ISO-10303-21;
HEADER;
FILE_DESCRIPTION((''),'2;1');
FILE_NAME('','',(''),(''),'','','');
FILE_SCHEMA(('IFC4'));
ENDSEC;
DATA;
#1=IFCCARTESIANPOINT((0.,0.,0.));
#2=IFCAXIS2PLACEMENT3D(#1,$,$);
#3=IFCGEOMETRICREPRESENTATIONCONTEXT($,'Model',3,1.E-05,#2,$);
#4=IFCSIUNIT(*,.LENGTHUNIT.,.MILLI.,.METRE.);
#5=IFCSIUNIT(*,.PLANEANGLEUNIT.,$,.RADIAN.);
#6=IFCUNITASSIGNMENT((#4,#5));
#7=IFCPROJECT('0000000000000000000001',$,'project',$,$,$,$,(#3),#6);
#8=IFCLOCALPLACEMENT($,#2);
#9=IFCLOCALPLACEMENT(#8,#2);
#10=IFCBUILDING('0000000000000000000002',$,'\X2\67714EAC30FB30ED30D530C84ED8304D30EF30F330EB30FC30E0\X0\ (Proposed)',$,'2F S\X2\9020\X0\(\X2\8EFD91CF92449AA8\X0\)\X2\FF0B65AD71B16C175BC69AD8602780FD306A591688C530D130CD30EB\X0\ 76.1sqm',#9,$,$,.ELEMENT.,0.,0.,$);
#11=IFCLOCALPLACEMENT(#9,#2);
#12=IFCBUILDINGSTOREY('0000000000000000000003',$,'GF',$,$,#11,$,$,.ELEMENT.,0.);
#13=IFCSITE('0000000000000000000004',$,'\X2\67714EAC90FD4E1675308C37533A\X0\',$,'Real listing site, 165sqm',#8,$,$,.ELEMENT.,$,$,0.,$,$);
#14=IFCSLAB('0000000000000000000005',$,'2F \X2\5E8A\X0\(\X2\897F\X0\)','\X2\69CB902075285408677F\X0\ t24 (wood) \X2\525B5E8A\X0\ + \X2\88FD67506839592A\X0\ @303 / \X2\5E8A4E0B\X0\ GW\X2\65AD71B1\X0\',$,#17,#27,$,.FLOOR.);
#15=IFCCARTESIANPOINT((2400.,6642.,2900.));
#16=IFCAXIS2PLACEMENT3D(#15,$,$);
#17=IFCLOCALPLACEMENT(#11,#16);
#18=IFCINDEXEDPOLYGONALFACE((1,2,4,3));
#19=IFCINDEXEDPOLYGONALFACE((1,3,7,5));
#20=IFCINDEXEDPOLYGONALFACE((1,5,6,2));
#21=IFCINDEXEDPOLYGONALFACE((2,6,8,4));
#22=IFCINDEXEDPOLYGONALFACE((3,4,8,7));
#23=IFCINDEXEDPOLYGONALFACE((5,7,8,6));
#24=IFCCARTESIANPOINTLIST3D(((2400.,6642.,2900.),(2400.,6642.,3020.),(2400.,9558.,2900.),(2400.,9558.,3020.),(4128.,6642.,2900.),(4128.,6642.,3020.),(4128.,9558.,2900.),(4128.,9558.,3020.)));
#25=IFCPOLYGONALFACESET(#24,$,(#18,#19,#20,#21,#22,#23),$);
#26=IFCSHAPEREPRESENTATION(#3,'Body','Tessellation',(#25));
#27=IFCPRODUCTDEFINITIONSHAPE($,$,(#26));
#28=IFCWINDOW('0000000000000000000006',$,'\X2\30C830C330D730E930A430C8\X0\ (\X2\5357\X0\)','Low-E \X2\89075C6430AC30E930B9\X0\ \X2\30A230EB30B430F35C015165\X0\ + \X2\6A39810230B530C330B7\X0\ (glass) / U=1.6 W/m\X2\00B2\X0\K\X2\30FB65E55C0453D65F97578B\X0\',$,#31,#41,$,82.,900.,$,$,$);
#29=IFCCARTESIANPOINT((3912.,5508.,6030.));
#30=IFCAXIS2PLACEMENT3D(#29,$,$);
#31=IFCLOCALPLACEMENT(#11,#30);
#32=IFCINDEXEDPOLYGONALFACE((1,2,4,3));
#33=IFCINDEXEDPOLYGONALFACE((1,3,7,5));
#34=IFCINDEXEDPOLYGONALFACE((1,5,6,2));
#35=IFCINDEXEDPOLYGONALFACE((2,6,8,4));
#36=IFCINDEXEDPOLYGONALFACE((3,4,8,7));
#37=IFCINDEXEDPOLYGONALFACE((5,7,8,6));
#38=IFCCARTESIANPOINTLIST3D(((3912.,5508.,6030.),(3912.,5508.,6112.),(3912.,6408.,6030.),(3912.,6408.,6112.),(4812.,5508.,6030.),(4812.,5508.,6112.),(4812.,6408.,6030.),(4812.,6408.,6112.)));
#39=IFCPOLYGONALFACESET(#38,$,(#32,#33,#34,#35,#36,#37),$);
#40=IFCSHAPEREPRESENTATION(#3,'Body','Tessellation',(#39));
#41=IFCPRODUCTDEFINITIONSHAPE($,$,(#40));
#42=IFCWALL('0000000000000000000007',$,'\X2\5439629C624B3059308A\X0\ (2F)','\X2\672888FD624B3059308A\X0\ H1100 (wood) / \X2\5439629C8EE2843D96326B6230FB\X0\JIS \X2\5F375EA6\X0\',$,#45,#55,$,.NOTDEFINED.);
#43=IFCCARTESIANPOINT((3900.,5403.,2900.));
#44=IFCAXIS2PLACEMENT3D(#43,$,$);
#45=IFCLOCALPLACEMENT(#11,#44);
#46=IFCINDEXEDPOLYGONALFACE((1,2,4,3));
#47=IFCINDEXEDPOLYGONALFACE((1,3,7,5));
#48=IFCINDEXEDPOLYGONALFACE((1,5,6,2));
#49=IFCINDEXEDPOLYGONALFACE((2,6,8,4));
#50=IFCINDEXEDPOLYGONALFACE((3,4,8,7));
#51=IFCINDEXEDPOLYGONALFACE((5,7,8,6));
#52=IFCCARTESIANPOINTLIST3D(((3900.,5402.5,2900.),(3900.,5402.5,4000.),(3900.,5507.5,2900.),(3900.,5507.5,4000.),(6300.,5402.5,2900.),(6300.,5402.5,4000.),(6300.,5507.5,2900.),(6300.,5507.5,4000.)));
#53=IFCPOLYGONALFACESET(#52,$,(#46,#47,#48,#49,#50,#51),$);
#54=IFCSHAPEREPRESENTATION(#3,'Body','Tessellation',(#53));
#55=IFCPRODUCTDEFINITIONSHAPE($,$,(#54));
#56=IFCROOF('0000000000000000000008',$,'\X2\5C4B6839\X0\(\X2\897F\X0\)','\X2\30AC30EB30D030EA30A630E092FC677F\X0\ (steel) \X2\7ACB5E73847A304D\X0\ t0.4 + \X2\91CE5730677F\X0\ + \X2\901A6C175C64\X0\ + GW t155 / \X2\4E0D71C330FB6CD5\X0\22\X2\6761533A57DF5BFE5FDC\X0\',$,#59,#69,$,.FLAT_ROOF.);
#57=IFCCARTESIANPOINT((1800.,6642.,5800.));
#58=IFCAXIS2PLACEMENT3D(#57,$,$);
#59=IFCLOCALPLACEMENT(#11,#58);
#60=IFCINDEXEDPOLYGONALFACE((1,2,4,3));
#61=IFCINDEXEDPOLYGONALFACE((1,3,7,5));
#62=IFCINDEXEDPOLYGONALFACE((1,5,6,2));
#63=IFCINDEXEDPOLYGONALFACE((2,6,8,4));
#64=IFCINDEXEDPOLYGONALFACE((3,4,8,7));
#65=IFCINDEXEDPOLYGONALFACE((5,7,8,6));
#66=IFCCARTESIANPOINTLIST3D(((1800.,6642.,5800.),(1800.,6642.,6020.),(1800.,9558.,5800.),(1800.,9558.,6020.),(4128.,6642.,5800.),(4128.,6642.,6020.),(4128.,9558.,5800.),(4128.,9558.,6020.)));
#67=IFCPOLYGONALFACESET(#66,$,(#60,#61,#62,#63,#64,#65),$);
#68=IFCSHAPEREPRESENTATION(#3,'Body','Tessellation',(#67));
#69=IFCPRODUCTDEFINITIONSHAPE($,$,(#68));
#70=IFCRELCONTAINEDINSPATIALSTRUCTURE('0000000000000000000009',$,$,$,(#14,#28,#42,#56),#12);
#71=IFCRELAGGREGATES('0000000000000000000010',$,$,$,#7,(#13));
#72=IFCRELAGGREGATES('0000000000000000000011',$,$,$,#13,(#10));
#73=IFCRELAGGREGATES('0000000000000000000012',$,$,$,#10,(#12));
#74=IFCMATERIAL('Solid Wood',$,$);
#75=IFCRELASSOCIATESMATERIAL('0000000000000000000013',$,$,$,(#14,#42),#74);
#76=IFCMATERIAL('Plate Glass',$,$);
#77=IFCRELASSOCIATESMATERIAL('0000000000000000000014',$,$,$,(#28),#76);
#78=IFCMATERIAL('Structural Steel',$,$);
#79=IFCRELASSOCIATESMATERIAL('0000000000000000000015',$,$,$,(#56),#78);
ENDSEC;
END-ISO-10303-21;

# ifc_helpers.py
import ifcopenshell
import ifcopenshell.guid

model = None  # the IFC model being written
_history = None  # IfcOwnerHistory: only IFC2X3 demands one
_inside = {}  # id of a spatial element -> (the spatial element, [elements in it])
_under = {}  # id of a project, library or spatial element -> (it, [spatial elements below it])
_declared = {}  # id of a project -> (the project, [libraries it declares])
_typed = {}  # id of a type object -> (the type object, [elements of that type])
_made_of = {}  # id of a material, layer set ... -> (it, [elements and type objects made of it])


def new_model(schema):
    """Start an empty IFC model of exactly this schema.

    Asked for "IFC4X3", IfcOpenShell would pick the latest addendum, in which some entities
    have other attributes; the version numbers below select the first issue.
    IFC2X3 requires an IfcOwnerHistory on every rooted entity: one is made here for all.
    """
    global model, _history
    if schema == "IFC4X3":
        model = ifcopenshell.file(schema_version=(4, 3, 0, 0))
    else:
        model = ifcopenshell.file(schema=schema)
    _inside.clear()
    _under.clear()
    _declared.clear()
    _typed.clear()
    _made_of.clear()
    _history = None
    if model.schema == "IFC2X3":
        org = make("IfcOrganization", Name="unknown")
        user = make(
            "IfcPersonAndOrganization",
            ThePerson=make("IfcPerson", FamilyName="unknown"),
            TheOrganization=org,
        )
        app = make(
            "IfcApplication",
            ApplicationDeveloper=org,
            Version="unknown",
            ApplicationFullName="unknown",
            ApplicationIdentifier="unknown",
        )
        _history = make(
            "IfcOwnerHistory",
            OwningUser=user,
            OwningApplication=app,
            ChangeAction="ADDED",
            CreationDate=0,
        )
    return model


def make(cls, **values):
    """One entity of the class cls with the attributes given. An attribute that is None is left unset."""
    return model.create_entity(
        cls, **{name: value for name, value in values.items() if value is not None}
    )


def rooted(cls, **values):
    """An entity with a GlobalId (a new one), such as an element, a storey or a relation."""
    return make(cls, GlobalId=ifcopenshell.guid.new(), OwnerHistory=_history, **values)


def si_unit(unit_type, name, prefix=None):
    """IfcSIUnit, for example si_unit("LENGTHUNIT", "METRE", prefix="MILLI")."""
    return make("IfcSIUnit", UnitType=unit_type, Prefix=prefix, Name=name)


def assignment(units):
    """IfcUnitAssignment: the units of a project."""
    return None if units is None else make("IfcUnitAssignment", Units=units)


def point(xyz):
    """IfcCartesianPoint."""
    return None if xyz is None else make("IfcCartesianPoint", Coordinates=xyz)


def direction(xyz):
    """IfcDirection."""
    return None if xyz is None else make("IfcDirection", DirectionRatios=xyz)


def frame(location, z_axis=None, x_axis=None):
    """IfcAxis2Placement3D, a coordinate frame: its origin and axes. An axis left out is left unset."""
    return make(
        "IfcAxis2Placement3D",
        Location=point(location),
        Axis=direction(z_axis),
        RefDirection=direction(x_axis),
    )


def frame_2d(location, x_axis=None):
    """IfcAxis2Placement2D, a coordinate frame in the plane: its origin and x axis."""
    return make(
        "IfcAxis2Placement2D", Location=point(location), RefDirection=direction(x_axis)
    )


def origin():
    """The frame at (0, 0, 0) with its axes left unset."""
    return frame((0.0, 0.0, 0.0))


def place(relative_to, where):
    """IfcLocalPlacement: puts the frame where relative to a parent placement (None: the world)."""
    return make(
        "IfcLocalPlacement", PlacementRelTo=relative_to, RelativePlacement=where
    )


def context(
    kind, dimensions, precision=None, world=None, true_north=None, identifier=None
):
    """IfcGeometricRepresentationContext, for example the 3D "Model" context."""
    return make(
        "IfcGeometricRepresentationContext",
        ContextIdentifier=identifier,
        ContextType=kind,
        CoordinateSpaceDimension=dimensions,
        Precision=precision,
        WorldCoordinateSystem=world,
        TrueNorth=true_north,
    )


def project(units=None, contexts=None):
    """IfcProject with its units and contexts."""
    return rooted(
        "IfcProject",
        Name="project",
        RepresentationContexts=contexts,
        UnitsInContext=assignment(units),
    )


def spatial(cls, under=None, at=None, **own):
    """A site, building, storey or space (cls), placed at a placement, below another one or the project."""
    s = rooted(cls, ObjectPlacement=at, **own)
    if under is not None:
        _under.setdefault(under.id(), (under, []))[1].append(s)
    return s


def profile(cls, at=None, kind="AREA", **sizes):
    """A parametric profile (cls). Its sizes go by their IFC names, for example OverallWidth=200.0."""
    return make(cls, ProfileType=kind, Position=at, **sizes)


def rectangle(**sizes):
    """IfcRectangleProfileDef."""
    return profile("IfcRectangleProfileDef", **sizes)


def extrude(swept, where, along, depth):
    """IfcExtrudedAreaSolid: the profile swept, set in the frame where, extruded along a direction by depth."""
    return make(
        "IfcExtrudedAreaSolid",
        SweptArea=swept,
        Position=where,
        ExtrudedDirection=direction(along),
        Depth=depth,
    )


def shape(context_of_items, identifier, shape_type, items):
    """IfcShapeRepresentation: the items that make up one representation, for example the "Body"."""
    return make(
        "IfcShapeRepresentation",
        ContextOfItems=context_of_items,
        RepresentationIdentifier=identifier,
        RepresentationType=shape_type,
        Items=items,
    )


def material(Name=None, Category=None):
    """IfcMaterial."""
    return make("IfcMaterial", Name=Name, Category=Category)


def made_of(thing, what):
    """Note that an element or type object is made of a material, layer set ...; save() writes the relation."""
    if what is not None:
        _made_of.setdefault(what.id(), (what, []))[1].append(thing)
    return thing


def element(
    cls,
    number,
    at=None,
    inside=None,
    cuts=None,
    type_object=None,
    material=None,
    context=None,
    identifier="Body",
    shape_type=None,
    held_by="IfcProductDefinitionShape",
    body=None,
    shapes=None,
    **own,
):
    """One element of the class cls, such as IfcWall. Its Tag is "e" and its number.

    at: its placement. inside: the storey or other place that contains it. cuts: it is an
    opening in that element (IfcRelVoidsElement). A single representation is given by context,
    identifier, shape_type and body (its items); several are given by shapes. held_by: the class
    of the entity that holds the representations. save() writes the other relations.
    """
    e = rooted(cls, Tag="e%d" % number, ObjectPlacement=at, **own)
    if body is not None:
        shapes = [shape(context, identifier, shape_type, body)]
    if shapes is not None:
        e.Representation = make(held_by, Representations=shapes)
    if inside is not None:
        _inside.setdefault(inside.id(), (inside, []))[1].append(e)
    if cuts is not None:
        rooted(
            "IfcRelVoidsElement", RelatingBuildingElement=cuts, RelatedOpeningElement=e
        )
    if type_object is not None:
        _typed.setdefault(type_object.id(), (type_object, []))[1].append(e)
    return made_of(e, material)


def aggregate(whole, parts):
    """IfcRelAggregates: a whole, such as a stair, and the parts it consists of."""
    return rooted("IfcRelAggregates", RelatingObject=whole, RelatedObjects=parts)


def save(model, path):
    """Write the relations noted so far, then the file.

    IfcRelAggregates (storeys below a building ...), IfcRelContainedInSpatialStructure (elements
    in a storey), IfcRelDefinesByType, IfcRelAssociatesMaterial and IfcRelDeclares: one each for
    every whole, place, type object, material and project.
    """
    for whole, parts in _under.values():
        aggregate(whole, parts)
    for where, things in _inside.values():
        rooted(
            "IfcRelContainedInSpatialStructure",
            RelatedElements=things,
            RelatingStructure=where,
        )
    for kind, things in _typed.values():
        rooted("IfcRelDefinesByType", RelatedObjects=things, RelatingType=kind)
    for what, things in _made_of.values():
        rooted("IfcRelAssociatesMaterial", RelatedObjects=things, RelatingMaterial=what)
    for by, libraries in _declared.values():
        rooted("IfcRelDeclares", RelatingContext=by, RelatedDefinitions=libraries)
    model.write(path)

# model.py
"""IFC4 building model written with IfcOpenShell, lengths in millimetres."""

from ifc_helpers import new_model, si_unit, frame, frame_2d, origin, place, context, project, spatial, rectangle, extrude, material, element, save


model = new_model("IFC4")

# Units and contexts
model_context = context("Model", 3, precision=1e-05, world=origin())
ifc_project = project(units=[si_unit("LENGTHUNIT", "METRE", prefix="MILLI"), si_unit("PLANEANGLEUNIT", "RADIAN")], contexts=[model_context])

# Site, building, storey
site_placement = place(None, origin())
site = spatial("IfcSite", under=ifc_project, at=site_placement, Name="東京都世田谷区", ObjectType="Real listing site, 165sqm", CompositionType="ELEMENT", RefElevation=0.0)
building_placement = place(site_placement, origin())
building = spatial("IfcBuilding", under=site, at=building_placement, Name="東京・ロフト付きワンルーム (Proposed)", ObjectType="2F S造(軽量鉄骨)＋断熱気密高性能な外装パネル 76.1sqm", CompositionType="ELEMENT", ElevationOfRefHeight=0.0, ElevationOfTerrain=0.0)
storey_placement = place(building_placement, origin())
storey = spatial("IfcBuildingStorey", under=building, at=storey_placement, Name="GF", CompositionType="ELEMENT", Elevation=0.0)

# Shared definitions
ifc_material_1 = material(Name="Solid Wood")

# Slab
slab_1_placement = place(storey_placement, frame((2400.0, 6642.0, 2900.0)))
element("IfcSlab", 1, at=slab_1_placement, inside=storey, material=ifc_material_1, Name="2F 床(西)", Description="構造用合板 t24 (wood) 剛床 + 製材根太 @303 / 床下 GW断熱", PredefinedType="FLOOR", context=model_context, shape_type="SweptSolid", body=[
    extrude(rectangle(XDim=1728.0, YDim=2916.0, at=frame_2d((864.0, 1458.0))), frame((2400.0, 6642.0, 2900.0)), (0.0, 0.0, 1.0), 120.0),
])

# Window
ifc_material_2 = material(Name="Plate Glass")
window_placement = place(storey_placement, frame((3912.0, 5508.0, 6030.0)))
element("IfcWindow", 2, at=window_placement, inside=storey, material=ifc_material_2, Name="トップライト (南)", Description="Low-E 複層ガラス アルゴン封入 + 樹脂サッシ (glass) / U=1.6 W/m²K・日射取得型", OverallHeight=82.0, OverallWidth=900.0, context=model_context, shape_type="SweptSolid", body=[
    extrude(rectangle(XDim=900.0, YDim=900.0, at=frame_2d((450.0, 450.0))), frame((3912.0, 5508.0, 6030.0)), (0.0, 0.0, 1.0), 82.0),
])

# Wall
wall_placement = place(storey_placement, frame((3900.0, 5403.0, 2900.0)))
element("IfcWall", 3, at=wall_placement, inside=storey, material=ifc_material_1, Name="吹抜手すり (2F)", Description="木製手すり H1100 (wood) / 吹抜転落防止・JIS 強度", PredefinedType="NOTDEFINED", context=model_context, shape_type="SweptSolid", body=[
    extrude(rectangle(XDim=2400.0, YDim=105.0, at=frame_2d((1200.0, 52.0))), frame((3900.0, 5403.0, 2900.0)), (0.0, 0.0, 1.0), 1100.0),
])

# Roof
ifc_material_3 = material(Name="Structural Steel")
for number, where, name in (
    (4, (1800.0, 6642.0, 5800.0), "屋根(西)"),
):
    element("IfcRoof", number, at=place(storey_placement, frame(where)), inside=storey, material=ifc_material_3, Name=name, Description="ガルバリウム鋼板 (steel) 立平葺き t0.4 + 野地板 + 通気層 + GW t155 / 不燃・法22条区域対応", PredefinedType="FLAT_ROOF", context=model_context, shape_type="SweptSolid", body=[
        extrude(rectangle(XDim=2328.0, YDim=2916.0, at=frame_2d((1164.0, 1458.0))), frame((1800.0, 6642.0, 5800.0)), (0.0, 0.0, 1.0), 220.0),
    ])

save(model, "model.ifc")
